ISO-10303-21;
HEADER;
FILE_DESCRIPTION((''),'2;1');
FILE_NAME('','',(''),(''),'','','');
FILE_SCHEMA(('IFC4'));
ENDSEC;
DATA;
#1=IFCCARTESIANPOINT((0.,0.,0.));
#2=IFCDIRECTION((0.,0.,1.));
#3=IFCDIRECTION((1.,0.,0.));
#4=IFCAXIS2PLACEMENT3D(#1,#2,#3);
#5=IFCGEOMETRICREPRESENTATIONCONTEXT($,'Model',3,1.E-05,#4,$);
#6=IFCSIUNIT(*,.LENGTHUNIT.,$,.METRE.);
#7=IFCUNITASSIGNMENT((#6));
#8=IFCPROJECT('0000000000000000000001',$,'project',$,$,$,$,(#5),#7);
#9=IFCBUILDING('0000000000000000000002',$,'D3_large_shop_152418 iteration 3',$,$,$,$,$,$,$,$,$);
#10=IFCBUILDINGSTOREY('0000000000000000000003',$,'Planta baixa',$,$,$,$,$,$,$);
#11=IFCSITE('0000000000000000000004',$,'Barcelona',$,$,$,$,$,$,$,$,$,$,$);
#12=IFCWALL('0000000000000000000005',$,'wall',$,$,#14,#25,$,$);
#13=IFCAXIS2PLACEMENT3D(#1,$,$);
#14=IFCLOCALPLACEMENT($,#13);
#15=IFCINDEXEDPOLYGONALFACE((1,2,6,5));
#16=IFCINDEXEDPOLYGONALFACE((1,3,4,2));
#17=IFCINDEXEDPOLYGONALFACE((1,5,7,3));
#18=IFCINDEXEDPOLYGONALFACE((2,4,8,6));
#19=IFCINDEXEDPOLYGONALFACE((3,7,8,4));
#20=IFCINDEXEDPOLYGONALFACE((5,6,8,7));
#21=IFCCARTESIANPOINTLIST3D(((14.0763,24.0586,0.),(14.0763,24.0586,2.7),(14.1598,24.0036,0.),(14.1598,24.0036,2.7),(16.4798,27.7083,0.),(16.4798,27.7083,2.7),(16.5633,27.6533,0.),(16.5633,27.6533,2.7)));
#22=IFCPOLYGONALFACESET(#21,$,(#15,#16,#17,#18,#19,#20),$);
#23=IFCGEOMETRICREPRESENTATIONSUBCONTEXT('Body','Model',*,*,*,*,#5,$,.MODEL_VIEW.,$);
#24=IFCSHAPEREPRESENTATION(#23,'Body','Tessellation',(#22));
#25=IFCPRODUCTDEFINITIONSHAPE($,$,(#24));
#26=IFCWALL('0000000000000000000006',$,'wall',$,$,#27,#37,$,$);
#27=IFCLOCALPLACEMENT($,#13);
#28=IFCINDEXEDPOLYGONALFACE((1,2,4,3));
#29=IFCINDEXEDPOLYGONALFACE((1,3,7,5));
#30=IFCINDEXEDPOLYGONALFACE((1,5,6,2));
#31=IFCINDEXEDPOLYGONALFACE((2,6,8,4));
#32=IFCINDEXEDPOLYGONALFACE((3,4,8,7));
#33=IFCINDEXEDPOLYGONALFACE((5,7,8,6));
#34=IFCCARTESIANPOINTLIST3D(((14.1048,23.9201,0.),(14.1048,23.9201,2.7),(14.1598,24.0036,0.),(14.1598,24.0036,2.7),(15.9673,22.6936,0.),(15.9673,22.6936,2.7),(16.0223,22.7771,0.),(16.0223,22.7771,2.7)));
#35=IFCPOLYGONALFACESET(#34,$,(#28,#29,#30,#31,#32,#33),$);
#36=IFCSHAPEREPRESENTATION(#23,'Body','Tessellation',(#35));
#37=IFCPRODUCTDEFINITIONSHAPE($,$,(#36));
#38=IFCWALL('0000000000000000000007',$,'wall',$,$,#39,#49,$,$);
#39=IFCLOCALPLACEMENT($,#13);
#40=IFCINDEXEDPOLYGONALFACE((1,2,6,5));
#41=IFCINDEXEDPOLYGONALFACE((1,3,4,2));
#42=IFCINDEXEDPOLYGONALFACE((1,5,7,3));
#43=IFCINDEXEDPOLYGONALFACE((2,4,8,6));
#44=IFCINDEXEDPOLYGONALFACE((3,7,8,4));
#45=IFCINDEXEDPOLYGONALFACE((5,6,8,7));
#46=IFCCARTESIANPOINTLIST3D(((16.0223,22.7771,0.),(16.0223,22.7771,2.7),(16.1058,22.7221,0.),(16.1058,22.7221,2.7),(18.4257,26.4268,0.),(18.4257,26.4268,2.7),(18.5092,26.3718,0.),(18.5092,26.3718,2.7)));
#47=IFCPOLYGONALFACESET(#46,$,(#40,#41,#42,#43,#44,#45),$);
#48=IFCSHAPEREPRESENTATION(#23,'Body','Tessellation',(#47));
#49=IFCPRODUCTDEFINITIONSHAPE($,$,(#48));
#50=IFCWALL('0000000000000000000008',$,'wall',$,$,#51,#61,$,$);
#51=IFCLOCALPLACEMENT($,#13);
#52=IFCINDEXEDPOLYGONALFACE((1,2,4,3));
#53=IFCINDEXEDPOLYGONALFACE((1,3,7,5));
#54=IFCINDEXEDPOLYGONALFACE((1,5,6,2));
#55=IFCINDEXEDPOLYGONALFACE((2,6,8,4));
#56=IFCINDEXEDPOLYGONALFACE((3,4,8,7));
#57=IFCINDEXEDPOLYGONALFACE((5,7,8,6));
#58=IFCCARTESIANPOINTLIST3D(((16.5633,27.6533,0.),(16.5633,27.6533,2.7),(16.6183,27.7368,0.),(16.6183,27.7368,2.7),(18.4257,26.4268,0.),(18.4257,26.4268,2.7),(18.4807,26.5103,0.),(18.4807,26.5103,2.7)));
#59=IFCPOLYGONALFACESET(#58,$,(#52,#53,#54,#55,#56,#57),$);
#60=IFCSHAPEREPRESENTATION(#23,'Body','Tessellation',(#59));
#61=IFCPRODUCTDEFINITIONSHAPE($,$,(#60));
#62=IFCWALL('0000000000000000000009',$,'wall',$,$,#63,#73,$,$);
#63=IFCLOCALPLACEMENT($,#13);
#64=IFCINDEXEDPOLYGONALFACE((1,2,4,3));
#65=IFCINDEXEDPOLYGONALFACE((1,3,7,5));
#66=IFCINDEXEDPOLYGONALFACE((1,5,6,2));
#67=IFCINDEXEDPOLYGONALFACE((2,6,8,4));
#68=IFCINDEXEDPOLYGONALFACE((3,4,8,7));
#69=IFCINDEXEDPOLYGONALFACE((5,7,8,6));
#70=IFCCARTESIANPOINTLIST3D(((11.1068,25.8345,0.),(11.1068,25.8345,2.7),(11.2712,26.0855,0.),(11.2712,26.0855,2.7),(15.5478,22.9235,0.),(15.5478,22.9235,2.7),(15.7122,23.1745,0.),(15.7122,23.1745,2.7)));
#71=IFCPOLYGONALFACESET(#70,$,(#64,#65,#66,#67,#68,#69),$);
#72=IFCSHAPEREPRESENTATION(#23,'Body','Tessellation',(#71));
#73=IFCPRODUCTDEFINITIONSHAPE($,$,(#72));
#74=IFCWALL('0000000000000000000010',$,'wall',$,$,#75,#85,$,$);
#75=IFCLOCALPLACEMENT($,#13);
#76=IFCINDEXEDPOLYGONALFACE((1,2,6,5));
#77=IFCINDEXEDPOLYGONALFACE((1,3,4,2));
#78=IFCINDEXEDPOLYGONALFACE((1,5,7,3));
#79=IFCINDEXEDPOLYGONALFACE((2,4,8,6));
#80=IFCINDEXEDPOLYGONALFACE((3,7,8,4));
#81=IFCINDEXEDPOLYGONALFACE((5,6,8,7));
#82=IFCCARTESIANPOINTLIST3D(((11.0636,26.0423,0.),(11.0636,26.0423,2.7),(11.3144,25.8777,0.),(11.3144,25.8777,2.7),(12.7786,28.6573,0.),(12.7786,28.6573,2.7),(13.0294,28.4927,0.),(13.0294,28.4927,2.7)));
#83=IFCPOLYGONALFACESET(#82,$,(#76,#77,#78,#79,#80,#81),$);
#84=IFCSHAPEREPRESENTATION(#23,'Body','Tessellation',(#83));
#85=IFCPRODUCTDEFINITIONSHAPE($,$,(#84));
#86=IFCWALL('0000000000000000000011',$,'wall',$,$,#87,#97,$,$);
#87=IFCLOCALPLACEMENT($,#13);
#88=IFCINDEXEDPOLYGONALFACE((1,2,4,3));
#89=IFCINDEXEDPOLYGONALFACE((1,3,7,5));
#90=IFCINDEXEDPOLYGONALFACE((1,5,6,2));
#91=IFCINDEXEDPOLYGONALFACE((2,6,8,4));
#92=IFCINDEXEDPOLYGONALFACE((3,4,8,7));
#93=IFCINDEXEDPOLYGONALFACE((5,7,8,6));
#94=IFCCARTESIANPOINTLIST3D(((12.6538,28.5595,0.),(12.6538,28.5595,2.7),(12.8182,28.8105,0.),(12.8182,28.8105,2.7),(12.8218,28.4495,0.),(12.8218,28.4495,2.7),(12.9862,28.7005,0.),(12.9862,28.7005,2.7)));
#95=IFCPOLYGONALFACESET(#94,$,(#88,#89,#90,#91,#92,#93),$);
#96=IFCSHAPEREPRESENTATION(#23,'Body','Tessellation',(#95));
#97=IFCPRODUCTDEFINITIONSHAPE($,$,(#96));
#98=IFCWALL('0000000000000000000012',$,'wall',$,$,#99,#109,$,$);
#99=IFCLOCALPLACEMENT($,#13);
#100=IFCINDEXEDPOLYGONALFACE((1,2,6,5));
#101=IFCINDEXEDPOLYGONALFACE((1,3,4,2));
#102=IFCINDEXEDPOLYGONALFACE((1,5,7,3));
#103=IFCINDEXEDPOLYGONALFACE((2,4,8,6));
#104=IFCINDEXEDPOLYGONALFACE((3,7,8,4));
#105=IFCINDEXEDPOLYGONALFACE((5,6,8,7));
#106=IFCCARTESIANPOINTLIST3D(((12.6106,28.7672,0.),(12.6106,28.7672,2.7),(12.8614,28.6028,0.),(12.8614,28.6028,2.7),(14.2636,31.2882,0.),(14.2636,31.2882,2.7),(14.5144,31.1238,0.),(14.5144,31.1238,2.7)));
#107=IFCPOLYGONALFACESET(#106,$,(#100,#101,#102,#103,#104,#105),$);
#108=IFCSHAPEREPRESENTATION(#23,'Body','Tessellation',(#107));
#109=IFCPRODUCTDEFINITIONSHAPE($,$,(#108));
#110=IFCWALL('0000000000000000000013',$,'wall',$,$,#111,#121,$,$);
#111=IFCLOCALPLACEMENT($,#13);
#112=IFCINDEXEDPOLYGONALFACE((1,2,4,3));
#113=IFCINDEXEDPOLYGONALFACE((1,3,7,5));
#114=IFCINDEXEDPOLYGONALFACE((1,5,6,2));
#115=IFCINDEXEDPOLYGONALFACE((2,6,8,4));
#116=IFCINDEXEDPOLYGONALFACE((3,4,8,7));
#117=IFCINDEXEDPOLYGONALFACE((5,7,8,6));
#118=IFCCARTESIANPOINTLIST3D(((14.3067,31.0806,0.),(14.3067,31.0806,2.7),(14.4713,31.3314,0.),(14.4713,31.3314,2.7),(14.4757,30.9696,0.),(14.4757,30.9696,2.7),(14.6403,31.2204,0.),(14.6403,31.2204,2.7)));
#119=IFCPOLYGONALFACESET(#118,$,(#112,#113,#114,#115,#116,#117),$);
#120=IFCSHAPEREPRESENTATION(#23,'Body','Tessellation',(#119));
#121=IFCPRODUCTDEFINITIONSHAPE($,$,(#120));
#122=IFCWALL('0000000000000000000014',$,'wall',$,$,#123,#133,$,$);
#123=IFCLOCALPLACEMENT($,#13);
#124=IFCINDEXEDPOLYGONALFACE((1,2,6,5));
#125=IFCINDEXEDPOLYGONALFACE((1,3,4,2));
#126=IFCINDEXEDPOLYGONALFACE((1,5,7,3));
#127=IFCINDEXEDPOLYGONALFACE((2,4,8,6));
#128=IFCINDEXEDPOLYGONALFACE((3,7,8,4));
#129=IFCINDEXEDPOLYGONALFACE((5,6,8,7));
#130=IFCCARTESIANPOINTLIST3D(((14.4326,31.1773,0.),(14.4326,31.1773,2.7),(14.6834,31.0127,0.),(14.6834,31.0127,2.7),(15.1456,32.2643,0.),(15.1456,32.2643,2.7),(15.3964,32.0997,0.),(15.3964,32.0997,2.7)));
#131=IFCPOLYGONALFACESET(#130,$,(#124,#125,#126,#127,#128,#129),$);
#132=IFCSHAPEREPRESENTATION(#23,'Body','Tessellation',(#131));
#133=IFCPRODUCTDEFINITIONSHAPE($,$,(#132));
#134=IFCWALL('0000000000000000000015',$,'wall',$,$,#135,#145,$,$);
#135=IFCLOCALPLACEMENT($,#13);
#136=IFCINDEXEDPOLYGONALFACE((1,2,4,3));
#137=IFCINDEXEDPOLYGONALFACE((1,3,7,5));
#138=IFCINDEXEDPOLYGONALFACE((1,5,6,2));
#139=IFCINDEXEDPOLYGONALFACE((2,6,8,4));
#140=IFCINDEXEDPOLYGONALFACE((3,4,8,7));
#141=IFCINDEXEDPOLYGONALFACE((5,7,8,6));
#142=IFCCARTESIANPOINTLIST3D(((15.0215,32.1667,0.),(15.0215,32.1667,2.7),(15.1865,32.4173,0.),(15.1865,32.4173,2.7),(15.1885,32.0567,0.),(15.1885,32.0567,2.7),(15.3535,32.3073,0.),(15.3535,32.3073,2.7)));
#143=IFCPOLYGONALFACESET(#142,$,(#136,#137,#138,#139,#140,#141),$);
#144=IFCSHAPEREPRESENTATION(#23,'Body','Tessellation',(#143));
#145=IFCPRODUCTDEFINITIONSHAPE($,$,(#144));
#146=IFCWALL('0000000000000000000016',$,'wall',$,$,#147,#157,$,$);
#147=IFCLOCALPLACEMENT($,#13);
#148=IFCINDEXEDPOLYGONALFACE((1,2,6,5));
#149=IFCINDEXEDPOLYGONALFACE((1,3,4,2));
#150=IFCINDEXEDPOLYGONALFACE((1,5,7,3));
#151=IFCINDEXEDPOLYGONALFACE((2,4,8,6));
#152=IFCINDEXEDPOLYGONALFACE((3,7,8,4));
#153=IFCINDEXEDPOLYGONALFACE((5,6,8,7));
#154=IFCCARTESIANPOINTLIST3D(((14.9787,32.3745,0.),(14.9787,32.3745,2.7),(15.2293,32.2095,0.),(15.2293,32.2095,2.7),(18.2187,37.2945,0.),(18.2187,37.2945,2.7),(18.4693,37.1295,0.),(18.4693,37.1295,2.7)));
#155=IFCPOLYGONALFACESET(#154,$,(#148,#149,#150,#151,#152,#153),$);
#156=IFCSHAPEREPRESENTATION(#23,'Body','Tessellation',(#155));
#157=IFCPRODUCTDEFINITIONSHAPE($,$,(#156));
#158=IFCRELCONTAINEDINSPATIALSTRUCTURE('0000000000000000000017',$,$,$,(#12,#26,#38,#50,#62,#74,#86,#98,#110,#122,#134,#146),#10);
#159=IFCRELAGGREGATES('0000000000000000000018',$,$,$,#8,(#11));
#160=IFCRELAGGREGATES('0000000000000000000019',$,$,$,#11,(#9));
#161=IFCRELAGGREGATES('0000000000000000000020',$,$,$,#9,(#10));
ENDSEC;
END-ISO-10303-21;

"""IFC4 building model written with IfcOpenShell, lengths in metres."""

from ifc_helpers import new_model, si_unit, origin, origin_with_axes, place, context, subcontext, project, spatial, polyline, outline, extrude, element, save


model = new_model("IFC4")

# Units and contexts
model_context = context("Model", 3, precision=1e-05, world=origin_with_axes())
body_context = subcontext(model_context, "Body", "Model", "MODEL_VIEW")
ifc_project = project(units=[si_unit("LENGTHUNIT", "METRE")], contexts=[model_context])

# Site, building, storey
site = spatial("IfcSite", under=ifc_project, Name="Barcelona")
building = spatial("IfcBuilding", under=site, Name="D3_large_shop_152418 iteration 3")
storey = spatial("IfcBuildingStorey", under=building, Name="Planta baixa")

# Walls
wall_1_placement = place(None, origin_with_axes())
element("IfcWall", 1, at=wall_1_placement, inside=storey, Name="wall", context=body_context, shape_type="SweptSolid", body=[
    extrude(outline(polyline([(16.5633, 27.6533), (14.1598, 24.0036), (14.0763, 24.0586), (16.4798, 27.7083), (16.5633, 27.6533)])), origin(), (0.0, 0.0, 1.0), 2.7),
])
wall_2_placement = place(None, origin_with_axes())
element("IfcWall", 2, at=wall_2_placement, inside=storey, Name="wall", context=body_context, shape_type="SweptSolid", body=[
    extrude(outline(polyline([(14.1598, 24.0036), (16.0223, 22.7771), (15.9673, 22.6936), (14.1048, 23.9201), (14.1598, 24.0036)])), origin(), (0.0, 0.0, 1.0), 2.7),
])
wall_3_placement = place(None, origin_with_axes())
element("IfcWall", 3, at=wall_3_placement, inside=storey, Name="wall", context=body_context, shape_type="SweptSolid", body=[
    extrude(outline(polyline([(16.0223, 22.7771), (18.4257, 26.4268), (18.5092, 26.3718), (16.1058, 22.7221), (16.0223, 22.7771)])), origin(), (0.0, 0.0, 1.0), 2.7),
])
wall_4_placement = place(None, origin_with_axes())
element("IfcWall", 4, at=wall_4_placement, inside=storey, Name="wall", context=body_context, shape_type="SweptSolid", body=[
    extrude(outline(polyline([(18.4257, 26.4268), (16.5633, 27.6533), (16.6183, 27.7368), (18.4807, 26.5103), (18.4257, 26.4268)])), origin(), (0.0, 0.0, 1.0), 2.7),
])
wall_5_placement = place(None, origin_with_axes())
element("IfcWall", 5, at=wall_5_placement, inside=storey, Name="wall", context=body_context, shape_type="SweptSolid", body=[
    extrude(outline(polyline([(15.5478, 22.9235), (11.1068, 25.8345), (11.2712, 26.0855), (15.7122, 23.1745), (15.5478, 22.9235)])), origin(), (0.0, 0.0, 1.0), 2.7),
])
wall_6_placement = place(None, origin_with_axes())
element("IfcWall", 6, at=wall_6_placement, inside=storey, Name="wall", context=body_context, shape_type="SweptSolid", body=[
    extrude(outline(polyline([(11.0636, 26.0423), (12.7786, 28.6573), (13.0294, 28.4927), (11.3144, 25.8777), (11.0636, 26.0423)])), origin(), (0.0, 0.0, 1.0), 2.7),
])
wall_7_placement = place(None, origin_with_axes())
element("IfcWall", 7, at=wall_7_placement, inside=storey, Name="wall", context=body_context, shape_type="SweptSolid", body=[
    extrude(outline(polyline([(12.8218, 28.4495), (12.6538, 28.5595), (12.8182, 28.8105), (12.9862, 28.7005), (12.8218, 28.4495)])), origin(), (0.0, 0.0, 1.0), 2.7),
])
wall_8_placement = place(None, origin_with_axes())
element("IfcWall", 8, at=wall_8_placement, inside=storey, Name="wall", context=body_context, shape_type="SweptSolid", body=[
    extrude(outline(polyline([(12.6106, 28.7672), (14.2636, 31.2882), (14.5144, 31.1238), (12.8614, 28.6028), (12.6106, 28.7672)])), origin(), (0.0, 0.0, 1.0), 2.7),
])
wall_9_placement = place(None, origin_with_axes())
element("IfcWall", 9, at=wall_9_placement, inside=storey, Name="wall", context=body_context, shape_type="SweptSolid", body=[
    extrude(outline(polyline([(14.4713, 31.3314), (14.6403, 31.2204), (14.4757, 30.9696), (14.3067, 31.0806), (14.4713, 31.3314)])), origin(), (0.0, 0.0, 1.0), 2.7),
])
wall_10_placement = place(None, origin_with_axes())
element("IfcWall", 10, at=wall_10_placement, inside=storey, Name="wall", context=body_context, shape_type="SweptSolid", body=[
    extrude(outline(polyline([(14.4326, 31.1773), (15.1456, 32.2643), (15.3964, 32.0997), (14.6834, 31.0127), (14.4326, 31.1773)])), origin(), (0.0, 0.0, 1.0), 2.7),
])
wall_11_placement = place(None, origin_with_axes())
element("IfcWall", 11, at=wall_11_placement, inside=storey, Name="wall", context=body_context, shape_type="SweptSolid", body=[
    extrude(outline(polyline([(15.1885, 32.0567), (15.0215, 32.1667), (15.1865, 32.4173), (15.3535, 32.3073), (15.1885, 32.0567)])), origin(), (0.0, 0.0, 1.0), 2.7),
])
wall_12_placement = place(None, origin_with_axes())
element("IfcWall", 12, at=wall_12_placement, inside=storey, Name="wall", context=body_context, shape_type="SweptSolid", body=[
    extrude(outline(polyline([(14.9787, 32.3745), (18.2187, 37.2945), (18.4693, 37.1295), (15.2293, 32.2095), (14.9787, 32.3745)])), origin(), (0.0, 0.0, 1.0), 2.7),
])

save(model, "model.ifc")
